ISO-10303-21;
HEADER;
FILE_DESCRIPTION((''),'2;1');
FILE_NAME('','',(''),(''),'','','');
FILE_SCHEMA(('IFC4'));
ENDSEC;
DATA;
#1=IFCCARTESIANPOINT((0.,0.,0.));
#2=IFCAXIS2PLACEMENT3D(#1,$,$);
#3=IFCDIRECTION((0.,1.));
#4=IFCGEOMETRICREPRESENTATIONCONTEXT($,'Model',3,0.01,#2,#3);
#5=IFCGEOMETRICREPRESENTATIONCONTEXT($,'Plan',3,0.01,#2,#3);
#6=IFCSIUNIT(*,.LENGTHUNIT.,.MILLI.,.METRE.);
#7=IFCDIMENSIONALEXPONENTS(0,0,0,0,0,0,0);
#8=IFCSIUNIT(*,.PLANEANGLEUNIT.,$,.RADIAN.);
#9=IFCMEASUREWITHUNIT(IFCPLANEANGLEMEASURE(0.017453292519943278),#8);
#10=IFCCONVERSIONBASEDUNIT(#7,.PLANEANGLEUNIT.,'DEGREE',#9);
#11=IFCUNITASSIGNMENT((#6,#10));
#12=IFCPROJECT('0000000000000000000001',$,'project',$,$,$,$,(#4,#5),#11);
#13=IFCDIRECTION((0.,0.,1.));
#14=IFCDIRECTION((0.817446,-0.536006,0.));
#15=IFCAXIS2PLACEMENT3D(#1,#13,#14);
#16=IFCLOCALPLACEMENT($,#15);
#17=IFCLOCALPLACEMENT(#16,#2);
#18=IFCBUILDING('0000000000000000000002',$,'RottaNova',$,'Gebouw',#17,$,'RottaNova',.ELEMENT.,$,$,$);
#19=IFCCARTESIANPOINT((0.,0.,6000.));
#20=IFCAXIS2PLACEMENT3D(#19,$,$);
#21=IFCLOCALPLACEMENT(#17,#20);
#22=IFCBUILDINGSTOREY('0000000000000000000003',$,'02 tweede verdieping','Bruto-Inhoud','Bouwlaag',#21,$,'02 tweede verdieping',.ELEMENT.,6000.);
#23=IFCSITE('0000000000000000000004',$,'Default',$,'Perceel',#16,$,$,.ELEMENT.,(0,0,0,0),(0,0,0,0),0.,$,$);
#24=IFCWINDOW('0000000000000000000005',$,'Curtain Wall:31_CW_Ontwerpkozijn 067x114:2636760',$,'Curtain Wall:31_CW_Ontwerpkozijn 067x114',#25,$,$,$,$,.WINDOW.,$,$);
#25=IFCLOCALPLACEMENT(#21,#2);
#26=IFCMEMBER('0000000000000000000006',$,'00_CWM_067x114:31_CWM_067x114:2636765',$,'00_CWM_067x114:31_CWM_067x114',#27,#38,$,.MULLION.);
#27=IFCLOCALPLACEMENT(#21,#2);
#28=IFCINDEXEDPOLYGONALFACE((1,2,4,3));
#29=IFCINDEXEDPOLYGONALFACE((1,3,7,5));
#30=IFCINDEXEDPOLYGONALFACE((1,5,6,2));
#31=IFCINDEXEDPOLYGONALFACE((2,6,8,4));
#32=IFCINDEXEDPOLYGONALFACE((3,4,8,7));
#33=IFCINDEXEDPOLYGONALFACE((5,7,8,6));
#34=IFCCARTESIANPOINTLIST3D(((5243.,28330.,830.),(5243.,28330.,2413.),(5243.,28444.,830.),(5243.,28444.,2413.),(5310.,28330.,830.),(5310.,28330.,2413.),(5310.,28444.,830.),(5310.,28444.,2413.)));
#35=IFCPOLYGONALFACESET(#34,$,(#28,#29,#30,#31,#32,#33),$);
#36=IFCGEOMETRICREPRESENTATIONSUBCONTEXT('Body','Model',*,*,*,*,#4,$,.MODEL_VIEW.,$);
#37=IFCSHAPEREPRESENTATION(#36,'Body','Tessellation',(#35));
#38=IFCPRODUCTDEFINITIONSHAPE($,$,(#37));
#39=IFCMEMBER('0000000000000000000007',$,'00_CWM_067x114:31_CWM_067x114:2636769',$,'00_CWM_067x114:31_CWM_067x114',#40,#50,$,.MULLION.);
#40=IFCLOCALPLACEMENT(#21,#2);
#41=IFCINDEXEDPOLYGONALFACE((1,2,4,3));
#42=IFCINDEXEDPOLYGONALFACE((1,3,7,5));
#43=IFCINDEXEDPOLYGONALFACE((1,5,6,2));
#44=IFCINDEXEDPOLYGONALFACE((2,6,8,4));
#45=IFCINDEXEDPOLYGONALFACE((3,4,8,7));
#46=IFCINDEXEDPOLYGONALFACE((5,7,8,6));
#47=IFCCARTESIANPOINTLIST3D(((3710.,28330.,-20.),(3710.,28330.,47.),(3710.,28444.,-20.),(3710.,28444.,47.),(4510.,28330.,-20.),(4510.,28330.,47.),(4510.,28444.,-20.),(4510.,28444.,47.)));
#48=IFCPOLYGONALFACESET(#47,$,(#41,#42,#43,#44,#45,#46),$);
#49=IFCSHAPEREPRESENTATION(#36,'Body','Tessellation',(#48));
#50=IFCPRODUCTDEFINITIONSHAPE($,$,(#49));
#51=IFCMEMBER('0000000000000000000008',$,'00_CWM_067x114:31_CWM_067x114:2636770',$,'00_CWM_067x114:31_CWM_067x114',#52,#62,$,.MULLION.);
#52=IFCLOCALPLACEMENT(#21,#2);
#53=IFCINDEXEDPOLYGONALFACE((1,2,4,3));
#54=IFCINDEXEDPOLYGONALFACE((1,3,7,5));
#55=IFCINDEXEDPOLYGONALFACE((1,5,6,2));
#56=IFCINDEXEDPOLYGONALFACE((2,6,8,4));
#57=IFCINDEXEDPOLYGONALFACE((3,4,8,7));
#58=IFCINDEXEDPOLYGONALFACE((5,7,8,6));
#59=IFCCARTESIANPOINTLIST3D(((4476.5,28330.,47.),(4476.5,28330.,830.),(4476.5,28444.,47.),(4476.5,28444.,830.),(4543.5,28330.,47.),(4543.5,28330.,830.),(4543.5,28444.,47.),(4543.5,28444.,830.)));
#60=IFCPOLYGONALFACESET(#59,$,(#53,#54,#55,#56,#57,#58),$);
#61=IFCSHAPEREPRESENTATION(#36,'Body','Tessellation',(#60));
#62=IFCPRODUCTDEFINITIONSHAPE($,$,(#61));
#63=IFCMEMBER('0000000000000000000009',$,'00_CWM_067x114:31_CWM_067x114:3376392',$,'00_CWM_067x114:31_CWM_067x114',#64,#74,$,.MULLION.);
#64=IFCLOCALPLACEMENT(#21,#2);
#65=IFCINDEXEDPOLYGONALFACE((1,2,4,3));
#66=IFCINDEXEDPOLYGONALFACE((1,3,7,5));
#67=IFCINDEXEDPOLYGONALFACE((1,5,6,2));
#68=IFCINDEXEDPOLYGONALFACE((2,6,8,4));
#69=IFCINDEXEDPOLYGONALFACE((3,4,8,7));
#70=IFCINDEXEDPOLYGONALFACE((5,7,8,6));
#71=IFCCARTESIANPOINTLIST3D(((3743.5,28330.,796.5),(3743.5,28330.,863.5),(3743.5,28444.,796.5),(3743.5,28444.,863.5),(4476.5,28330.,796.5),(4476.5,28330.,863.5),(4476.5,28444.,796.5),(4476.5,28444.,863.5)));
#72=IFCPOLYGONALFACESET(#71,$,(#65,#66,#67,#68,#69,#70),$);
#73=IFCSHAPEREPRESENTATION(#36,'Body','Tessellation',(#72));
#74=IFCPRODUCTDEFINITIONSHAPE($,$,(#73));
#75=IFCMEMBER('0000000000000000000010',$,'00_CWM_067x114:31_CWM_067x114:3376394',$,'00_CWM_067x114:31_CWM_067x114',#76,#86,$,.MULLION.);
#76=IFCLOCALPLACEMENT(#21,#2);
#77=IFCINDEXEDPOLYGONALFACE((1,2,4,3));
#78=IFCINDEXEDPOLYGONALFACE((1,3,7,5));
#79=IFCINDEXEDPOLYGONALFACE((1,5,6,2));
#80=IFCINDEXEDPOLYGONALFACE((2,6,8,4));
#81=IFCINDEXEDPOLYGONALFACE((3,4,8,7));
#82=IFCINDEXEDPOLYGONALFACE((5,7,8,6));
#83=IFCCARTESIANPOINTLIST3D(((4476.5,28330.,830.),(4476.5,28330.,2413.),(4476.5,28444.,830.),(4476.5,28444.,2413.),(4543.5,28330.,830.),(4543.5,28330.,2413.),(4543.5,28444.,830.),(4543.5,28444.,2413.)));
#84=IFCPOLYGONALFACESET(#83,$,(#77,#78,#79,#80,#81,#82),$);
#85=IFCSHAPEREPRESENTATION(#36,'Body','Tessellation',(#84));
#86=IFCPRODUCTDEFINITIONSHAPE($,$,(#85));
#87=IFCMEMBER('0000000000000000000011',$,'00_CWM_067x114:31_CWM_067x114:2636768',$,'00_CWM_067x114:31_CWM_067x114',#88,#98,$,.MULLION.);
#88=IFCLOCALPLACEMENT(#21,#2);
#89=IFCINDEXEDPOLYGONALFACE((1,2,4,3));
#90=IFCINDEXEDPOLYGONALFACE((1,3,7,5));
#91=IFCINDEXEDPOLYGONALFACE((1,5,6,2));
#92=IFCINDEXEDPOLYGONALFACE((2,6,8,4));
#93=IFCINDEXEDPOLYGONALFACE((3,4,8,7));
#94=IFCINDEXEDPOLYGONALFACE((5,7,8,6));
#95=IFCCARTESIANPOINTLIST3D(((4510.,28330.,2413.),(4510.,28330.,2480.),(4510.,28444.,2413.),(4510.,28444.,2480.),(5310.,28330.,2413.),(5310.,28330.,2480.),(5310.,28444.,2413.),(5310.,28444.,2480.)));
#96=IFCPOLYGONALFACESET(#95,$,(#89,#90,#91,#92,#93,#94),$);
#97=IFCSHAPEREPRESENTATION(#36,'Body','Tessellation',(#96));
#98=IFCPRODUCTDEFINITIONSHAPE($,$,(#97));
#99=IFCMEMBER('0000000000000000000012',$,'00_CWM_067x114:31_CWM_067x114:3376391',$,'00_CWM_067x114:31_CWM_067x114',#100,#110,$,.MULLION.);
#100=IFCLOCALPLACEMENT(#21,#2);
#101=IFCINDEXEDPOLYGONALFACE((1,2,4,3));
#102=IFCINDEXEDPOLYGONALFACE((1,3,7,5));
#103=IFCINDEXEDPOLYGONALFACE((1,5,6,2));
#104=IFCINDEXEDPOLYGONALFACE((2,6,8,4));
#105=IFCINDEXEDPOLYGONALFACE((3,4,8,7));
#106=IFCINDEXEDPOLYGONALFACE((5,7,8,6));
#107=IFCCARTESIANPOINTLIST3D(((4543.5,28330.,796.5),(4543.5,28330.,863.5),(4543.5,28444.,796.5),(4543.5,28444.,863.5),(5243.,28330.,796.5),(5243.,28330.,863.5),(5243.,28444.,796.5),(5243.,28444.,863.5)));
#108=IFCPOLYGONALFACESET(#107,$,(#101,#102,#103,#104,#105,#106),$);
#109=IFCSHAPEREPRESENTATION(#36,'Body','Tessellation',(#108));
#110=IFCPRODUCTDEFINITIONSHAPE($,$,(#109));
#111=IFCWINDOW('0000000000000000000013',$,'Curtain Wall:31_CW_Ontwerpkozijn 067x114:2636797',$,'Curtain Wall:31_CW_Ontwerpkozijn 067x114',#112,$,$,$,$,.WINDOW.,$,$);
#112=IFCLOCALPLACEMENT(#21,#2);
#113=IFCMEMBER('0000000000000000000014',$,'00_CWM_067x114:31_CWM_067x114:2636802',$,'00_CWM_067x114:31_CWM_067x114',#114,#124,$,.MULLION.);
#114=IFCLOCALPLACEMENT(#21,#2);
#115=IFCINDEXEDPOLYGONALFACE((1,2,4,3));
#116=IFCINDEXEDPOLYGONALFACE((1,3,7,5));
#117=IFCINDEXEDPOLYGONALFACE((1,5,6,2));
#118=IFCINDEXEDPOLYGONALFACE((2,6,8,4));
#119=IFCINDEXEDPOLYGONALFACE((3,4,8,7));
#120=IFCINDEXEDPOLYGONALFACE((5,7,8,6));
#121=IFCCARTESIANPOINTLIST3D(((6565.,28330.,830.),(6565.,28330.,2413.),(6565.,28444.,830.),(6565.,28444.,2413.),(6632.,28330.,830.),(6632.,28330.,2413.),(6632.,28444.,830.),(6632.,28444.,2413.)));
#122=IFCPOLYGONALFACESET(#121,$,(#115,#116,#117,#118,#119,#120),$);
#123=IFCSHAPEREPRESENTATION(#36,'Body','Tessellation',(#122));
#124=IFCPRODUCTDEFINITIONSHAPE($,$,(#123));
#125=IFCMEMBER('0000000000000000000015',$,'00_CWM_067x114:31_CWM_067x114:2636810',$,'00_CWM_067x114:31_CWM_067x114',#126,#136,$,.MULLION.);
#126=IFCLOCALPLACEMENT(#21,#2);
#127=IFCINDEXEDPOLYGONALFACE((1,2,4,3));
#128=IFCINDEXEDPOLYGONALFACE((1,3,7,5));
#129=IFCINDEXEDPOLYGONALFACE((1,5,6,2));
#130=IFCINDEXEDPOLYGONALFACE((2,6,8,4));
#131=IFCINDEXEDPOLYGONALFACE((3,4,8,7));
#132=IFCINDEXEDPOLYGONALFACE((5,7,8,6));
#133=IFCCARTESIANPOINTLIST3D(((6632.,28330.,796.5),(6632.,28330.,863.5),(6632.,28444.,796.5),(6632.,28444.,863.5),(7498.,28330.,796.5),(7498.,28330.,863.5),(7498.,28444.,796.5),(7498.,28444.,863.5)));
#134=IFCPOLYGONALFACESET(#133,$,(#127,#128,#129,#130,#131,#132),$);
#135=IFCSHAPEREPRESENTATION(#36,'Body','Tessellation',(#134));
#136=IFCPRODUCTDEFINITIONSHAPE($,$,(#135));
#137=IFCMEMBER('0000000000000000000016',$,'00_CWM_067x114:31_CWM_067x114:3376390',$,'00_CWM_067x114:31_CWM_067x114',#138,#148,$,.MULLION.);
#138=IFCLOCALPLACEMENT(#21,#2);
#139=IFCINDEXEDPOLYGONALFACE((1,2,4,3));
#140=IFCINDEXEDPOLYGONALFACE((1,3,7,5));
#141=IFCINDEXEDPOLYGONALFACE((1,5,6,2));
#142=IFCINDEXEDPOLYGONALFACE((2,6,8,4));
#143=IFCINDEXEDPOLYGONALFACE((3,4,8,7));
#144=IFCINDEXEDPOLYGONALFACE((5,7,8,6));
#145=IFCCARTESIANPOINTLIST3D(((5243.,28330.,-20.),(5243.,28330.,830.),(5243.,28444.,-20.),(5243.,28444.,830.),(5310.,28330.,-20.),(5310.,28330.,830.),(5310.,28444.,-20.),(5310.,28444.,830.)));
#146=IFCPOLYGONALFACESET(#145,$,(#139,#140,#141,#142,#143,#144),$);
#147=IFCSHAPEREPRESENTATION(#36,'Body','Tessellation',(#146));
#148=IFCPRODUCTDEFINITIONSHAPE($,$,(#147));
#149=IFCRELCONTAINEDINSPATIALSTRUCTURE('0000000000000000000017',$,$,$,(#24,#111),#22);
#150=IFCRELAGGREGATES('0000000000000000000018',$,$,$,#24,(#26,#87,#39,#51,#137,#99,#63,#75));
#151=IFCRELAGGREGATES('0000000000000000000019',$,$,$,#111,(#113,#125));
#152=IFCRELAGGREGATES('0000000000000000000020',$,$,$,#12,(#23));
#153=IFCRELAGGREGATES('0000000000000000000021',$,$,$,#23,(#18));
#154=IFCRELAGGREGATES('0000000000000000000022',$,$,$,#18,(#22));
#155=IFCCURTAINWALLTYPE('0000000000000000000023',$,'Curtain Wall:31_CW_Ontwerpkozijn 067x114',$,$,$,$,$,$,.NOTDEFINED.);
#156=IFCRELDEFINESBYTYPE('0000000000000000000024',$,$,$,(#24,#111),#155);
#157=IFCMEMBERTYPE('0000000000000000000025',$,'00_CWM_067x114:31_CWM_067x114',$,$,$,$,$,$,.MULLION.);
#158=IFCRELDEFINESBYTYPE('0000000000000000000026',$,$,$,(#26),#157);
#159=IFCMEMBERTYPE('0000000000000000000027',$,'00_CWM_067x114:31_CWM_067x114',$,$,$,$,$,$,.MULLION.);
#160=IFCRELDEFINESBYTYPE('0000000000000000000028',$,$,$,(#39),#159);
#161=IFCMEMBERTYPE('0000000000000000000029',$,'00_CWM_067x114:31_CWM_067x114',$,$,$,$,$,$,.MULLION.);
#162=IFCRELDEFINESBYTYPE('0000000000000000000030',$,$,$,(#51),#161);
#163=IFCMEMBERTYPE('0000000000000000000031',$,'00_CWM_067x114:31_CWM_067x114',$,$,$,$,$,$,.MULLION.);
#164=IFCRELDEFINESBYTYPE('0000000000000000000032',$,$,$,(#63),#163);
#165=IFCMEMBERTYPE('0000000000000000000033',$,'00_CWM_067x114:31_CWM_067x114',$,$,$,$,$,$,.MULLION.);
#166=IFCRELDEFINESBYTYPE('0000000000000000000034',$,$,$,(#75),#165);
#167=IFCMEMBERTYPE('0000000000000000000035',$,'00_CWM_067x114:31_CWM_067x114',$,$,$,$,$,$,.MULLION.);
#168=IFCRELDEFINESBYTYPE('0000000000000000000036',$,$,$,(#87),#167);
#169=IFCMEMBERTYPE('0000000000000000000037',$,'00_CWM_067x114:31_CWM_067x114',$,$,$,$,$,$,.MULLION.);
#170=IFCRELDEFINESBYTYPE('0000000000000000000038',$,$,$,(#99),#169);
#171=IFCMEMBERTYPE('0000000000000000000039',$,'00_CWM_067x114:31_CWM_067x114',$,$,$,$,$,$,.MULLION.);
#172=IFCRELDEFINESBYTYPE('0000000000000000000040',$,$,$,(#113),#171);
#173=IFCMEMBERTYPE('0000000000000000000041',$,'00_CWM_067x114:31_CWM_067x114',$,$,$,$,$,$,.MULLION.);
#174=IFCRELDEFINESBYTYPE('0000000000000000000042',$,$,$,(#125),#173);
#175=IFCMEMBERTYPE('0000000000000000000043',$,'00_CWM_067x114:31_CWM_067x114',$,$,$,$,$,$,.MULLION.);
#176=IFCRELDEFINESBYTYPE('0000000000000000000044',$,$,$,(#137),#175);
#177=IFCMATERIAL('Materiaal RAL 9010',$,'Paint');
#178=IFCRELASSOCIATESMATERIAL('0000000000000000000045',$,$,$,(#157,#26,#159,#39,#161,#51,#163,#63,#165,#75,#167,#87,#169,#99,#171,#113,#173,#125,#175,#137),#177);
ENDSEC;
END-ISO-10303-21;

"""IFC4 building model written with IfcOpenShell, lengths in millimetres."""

from ifc_helpers import new_model, entity, si_unit, converted_unit, direction, frame, origin, place, context, subcontext, project, spatial, indexed_curve, outline, extrude, source, transform, mapped, material, type_object, type_shapes, element, aggregate, save


model = new_model("IFC4")

# Units and contexts
model_context = context("Model", 3, precision=0.01, world=origin(), true_north=direction((0.0, 1.0)))
plan_context = context("Plan", 3, precision=0.01, world=origin(), true_north=direction((0.0, 1.0)))
body_context = subcontext(model_context, "Body", "Model", "MODEL_VIEW")
ifc_project = project(units=[si_unit("LENGTHUNIT", "METRE", prefix="MILLI"), converted_unit("PLANEANGLEUNIT", "DEGREE", entity("IfcPlaneAngleMeasure", 0.017453292519943278), si_unit("PLANEANGLEUNIT", "RADIAN"), dimensions=[0, 0, 0, 0, 0, 0, 0])], contexts=[model_context, plan_context])

# Site, building, storey
site_placement = place(None, frame((0.0, 0.0, 0.0), z_axis=(0.0, 0.0, 1.0), x_axis=(0.817446, -0.536006, 0.0)))
site = spatial("IfcSite", under=ifc_project, at=site_placement, Name="Default", ObjectType="Perceel", CompositionType="ELEMENT", RefLatitude=(0, 0, 0, 0), RefLongitude=(0, 0, 0, 0), RefElevation=0.0)
building_placement = place(site_placement, origin())
building = spatial("IfcBuilding", under=site, at=building_placement, Name="RottaNova", ObjectType="Gebouw", LongName="RottaNova", CompositionType="ELEMENT")
storey_placement = place(building_placement, frame((0.0, 0.0, 6000.0)))
storey = spatial("IfcBuildingStorey", under=building, at=storey_placement, Name="02 tweede verdieping", Description="Bruto-Inhoud", ObjectType="Bouwlaag", LongName="02 tweede verdieping", CompositionType="ELEMENT", Elevation=6000.0)

# Windows, members
curtain_wall_type = type_object("IfcCurtainWallType", Name="Curtain Wall:31_CW_Ontwerpkozijn 067x114", PredefinedType="NOTDEFINED")
window_1_placement = place(storey_placement, frame((0.0, 0.0, -6000.0)))
window_1 = element("IfcWindow", 1, at=window_1_placement, inside=storey, type_object=curtain_wall_type, Name="Curtain Wall:31_CW_Ontwerpkozijn 067x114:2636760", ObjectType="Curtain Wall:31_CW_Ontwerpkozijn 067x114", PredefinedType="WINDOW")
ifc_material_1 = material(Name="Materiaal RAL 9010", Category="Paint")
member_type_1 = type_object("IfcMemberType", Name="00_CWM_067x114:31_CWM_067x114", PredefinedType="MULLION", material=ifc_material_1)
shared_shape_1 = source(origin(), body_context, "Body", "SweptSolid", [
    extrude(outline(indexed_curve([(-33.5, -57.0), (33.5, -57.0), (33.5, 57.0), (-33.5, 57.0), (-33.5, -57.0)], self_intersect=False)), frame((-33.5, 57.0, -1583.0), z_axis=(0.0, 0.0, 1.0), x_axis=(-1.0, 0.0, 0.0)), (0.0, 0.0, 1.0), 1583.0),
])
type_shapes(member_type_1, [shared_shape_1])
member_1_placement = place(window_1_placement, frame((5310.0, 28330.0, 8413.0)))
member_1 = element("IfcMember", 2, at=member_1_placement, type_object=member_type_1, material=ifc_material_1, Name="00_CWM_067x114:31_CWM_067x114:2636765", ObjectType="00_CWM_067x114:31_CWM_067x114", PredefinedType="MULLION", context=body_context, shape_type="MappedRepresentation", body=[
    mapped(shared_shape_1, transform((0.0, 0.0, 0.0), scale=1.0)),
])
member_type_2 = type_object("IfcMemberType", Name="00_CWM_067x114:31_CWM_067x114", PredefinedType="MULLION", material=ifc_material_1)
shared_shape_2 = source(origin(), body_context, "Body", "SweptSolid", [
    extrude(outline(indexed_curve([(-33.5, -57.0), (33.5, -57.0), (33.5, 57.0), (-33.5, 57.0), (-33.5, -57.0)], self_intersect=False)), frame((-33.5, 57.0, -800.0), z_axis=(0.0, 0.0, 1.0), x_axis=(-1.0, 0.0, 0.0)), (0.0, 0.0, 1.0), 800.0),
])
type_shapes(member_type_2, [shared_shape_2])
member_2_placement = place(window_1_placement, frame((4510.0, 28330.0, 5980.0), z_axis=(1.0, 0.0, 0.0), x_axis=(0.0, 0.0, -1.0)))
member_2 = element("IfcMember", 3, at=member_2_placement, type_object=member_type_2, material=ifc_material_1, Name="00_CWM_067x114:31_CWM_067x114:2636769", ObjectType="00_CWM_067x114:31_CWM_067x114", PredefinedType="MULLION", context=body_context, shape_type="MappedRepresentation", body=[
    mapped(shared_shape_2, transform((0.0, 0.0, 0.0), scale=1.0)),
])
member_type_3 = type_object("IfcMemberType", Name="00_CWM_067x114:31_CWM_067x114", PredefinedType="MULLION", material=ifc_material_1)
shared_shape_3 = source(origin(), body_context, "Body", "SweptSolid", [
    extrude(outline(indexed_curve([(-33.5, -57.0), (33.5, -57.0), (33.5, 57.0), (-33.5, 57.0), (-33.5, -57.0)], self_intersect=False)), frame((0.0, 57.0, -783.0), z_axis=(0.0, 0.0, 1.0), x_axis=(-1.0, 0.0, 0.0)), (0.0, 0.0, 1.0), 783.0),
])
type_shapes(member_type_3, [shared_shape_3])
member_3_placement = place(window_1_placement, frame((4510.0, 28330.0, 6047.0), z_axis=(0.0, 0.0, -1.0), x_axis=(-1.0, 0.0, 0.0)))
member_3 = element("IfcMember", 4, at=member_3_placement, type_object=member_type_3, material=ifc_material_1, Name="00_CWM_067x114:31_CWM_067x114:2636770", ObjectType="00_CWM_067x114:31_CWM_067x114", PredefinedType="MULLION", context=body_context, shape_type="MappedRepresentation", body=[
    mapped(shared_shape_3, transform((0.0, 0.0, 0.0), scale=1.0)),
])
member_type_4 = type_object("IfcMemberType", Name="00_CWM_067x114:31_CWM_067x114", PredefinedType="MULLION", material=ifc_material_1)
shared_shape_4 = source(origin(), body_context, "Body", "SweptSolid", [
    extrude(outline(indexed_curve([(-33.5, -57.0), (33.5, -57.0), (33.5, 57.0), (-33.5, 57.0), (-33.5, -57.0)], self_intersect=False)), frame((0.0, 57.0, -733.0), z_axis=(0.0, 0.0, 1.0), x_axis=(-1.0, 0.0, 0.0)), (0.0, 0.0, 1.0), 733.0),
])
type_shapes(member_type_4, [shared_shape_4])
member_4_placement = place(window_1_placement, frame((3743.5, 28330.0, 6830.0), z_axis=(-1.0, 0.0, 0.0), x_axis=(0.0, 0.0, 1.0)))
member_4 = element("IfcMember", 5, at=member_4_placement, type_object=member_type_4, material=ifc_material_1, Name="00_CWM_067x114:31_CWM_067x114:3376392", ObjectType="00_CWM_067x114:31_CWM_067x114", PredefinedType="MULLION", context=body_context, shape_type="MappedRepresentation", body=[
    mapped(shared_shape_4, transform((0.0, 0.0, 0.0), scale=1.0)),
])
member_type_5 = type_object("IfcMemberType", Name="00_CWM_067x114:31_CWM_067x114", PredefinedType="MULLION", material=ifc_material_1)
shared_shape_5 = source(origin(), body_context, "Body", "SweptSolid", [
    extrude(outline(indexed_curve([(-33.5, -57.0), (33.5, -57.0), (33.5, 57.0), (-33.5, 57.0), (-33.5, -57.0)], self_intersect=False)), frame((0.0, 57.0, -1583.0), z_axis=(0.0, 0.0, 1.0), x_axis=(-1.0, 0.0, 0.0)), (0.0, 0.0, 1.0), 1583.0),
])
type_shapes(member_type_5, [shared_shape_5])
member_5_placement = place(window_1_placement, frame((4510.0, 28330.0, 6830.0), z_axis=(0.0, 0.0, -1.0), x_axis=(-1.0, 0.0, 0.0)))
member_5 = element("IfcMember", 6, at=member_5_placement, type_object=member_type_5, material=ifc_material_1, Name="00_CWM_067x114:31_CWM_067x114:3376394", ObjectType="00_CWM_067x114:31_CWM_067x114", PredefinedType="MULLION", context=body_context, shape_type="MappedRepresentation", body=[
    mapped(shared_shape_5, transform((0.0, 0.0, 0.0), scale=1.0)),
])
member_type_6 = type_object("IfcMemberType", Name="00_CWM_067x114:31_CWM_067x114", PredefinedType="MULLION", material=ifc_material_1)
shared_shape_6 = source(origin(), body_context, "Body", "SweptSolid", [
    extrude(outline(indexed_curve([(-33.5, -57.0), (33.5, -57.0), (33.5, 57.0), (-33.5, 57.0), (-33.5, -57.0)], self_intersect=False)), frame((-33.5, 57.0, -800.0), z_axis=(0.0, 0.0, 1.0), x_axis=(-1.0, 0.0, 0.0)), (0.0, 0.0, 1.0), 800.0),
])
type_shapes(member_type_6, [shared_shape_6])
member_6_placement = place(window_1_placement, frame((4510.0, 28330.0, 8480.0), z_axis=(-1.0, 0.0, 0.0), x_axis=(0.0, 0.0, 1.0)))
member_6 = element("IfcMember", 7, at=member_6_placement, type_object=member_type_6, material=ifc_material_1, Name="00_CWM_067x114:31_CWM_067x114:2636768", ObjectType="00_CWM_067x114:31_CWM_067x114", PredefinedType="MULLION", context=body_context, shape_type="MappedRepresentation", body=[
    mapped(shared_shape_6, transform((0.0, 0.0, 0.0), scale=1.0)),
])
member_type_7 = type_object("IfcMemberType", Name="00_CWM_067x114:31_CWM_067x114", PredefinedType="MULLION", material=ifc_material_1)
shared_shape_7 = source(origin(), body_context, "Body", "SweptSolid", [
    extrude(outline(indexed_curve([(-33.5, -57.0), (33.5, -57.0), (33.5, 57.0), (-33.5, 57.0), (-33.5, -57.0)], self_intersect=False)), frame((0.0, 57.0, -699.5), z_axis=(0.0, 0.0, 1.0), x_axis=(-1.0, 0.0, 0.0)), (0.0, 0.0, 1.0), 699.5),
])
type_shapes(member_type_7, [shared_shape_7])
member_7_placement = place(window_1_placement, frame((4543.5, 28330.0, 6830.0), z_axis=(-1.0, 0.0, 0.0), x_axis=(0.0, 0.0, 1.0)))
member_7 = element("IfcMember", 8, at=member_7_placement, type_object=member_type_7, material=ifc_material_1, Name="00_CWM_067x114:31_CWM_067x114:3376391", ObjectType="00_CWM_067x114:31_CWM_067x114", PredefinedType="MULLION", context=body_context, shape_type="MappedRepresentation", body=[
    mapped(shared_shape_7, transform((0.0, 0.0, 0.0), scale=1.0)),
])
window_2_placement = place(storey_placement, frame((0.0, 0.0, -6000.0)))
window_2 = element("IfcWindow", 9, at=window_2_placement, inside=storey, type_object=curtain_wall_type, Name="Curtain Wall:31_CW_Ontwerpkozijn 067x114:2636797", ObjectType="Curtain Wall:31_CW_Ontwerpkozijn 067x114", PredefinedType="WINDOW")
member_type_8 = type_object("IfcMemberType", Name="00_CWM_067x114:31_CWM_067x114", PredefinedType="MULLION", material=ifc_material_1)
shared_shape_8 = source(origin(), body_context, "Body", "SweptSolid", [
    extrude(outline(indexed_curve([(-33.5, -57.0), (33.5, -57.0), (33.5, 57.0), (-33.5, 57.0), (-33.5, -57.0)], self_intersect=False)), frame((-33.5, -57.0, -1583.0), z_axis=(0.0, 0.0, 1.0), x_axis=(-1.0, 0.0, 0.0)), (0.0, 0.0, 1.0), 1583.0),
])
type_shapes(member_type_8, [shared_shape_8])
member_8_placement = place(window_2_placement, frame((6565.0, 28330.0, 8413.0), z_axis=(0.0, 0.0, 1.0), x_axis=(-1.0, 0.0, 0.0)))
member_8 = element("IfcMember", 10, at=member_8_placement, type_object=member_type_8, material=ifc_material_1, Name="00_CWM_067x114:31_CWM_067x114:2636802", ObjectType="00_CWM_067x114:31_CWM_067x114", PredefinedType="MULLION", context=body_context, shape_type="MappedRepresentation", body=[
    mapped(shared_shape_8, transform((0.0, 0.0, 0.0), scale=1.0)),
])
member_type_9 = type_object("IfcMemberType", Name="00_CWM_067x114:31_CWM_067x114", PredefinedType="MULLION", material=ifc_material_1)
shared_shape_9 = source(origin(), body_context, "Body", "SweptSolid", [
    extrude(outline(indexed_curve([(-33.5, -57.0), (33.5, -57.0), (33.5, 57.0), (-33.5, 57.0), (-33.5, -57.0)], self_intersect=False)), frame((0.0, -57.0, -866.0), z_axis=(0.0, 0.0, 1.0), x_axis=(-1.0, 0.0, 0.0)), (0.0, 0.0, 1.0), 866.0),
])
type_shapes(member_type_9, [shared_shape_9])
member_9_placement = place(window_2_placement, frame((7498.0, 28330.0, 6830.0), z_axis=(1.0, 0.0, 0.0), x_axis=(0.0, 0.0, 1.0)))
member_9 = element("IfcMember", 11, at=member_9_placement, type_object=member_type_9, material=ifc_material_1, Name="00_CWM_067x114:31_CWM_067x114:2636810", ObjectType="00_CWM_067x114:31_CWM_067x114", PredefinedType="MULLION", context=body_context, shape_type="MappedRepresentation", body=[
    mapped(shared_shape_9, transform((0.0, 0.0, 0.0), scale=1.0)),
])

# Member
member_type_10 = type_object("IfcMemberType", Name="00_CWM_067x114:31_CWM_067x114", PredefinedType="MULLION", material=ifc_material_1)
shared_shape_10 = source(origin(), body_context, "Body", "SweptSolid", [
    extrude(outline(indexed_curve([(-33.5, -57.0), (33.5, -57.0), (33.5, 57.0), (-33.5, 57.0), (-33.5, -57.0)], self_intersect=False)), frame((-33.5, 57.0, -850.0), z_axis=(0.0, 0.0, 1.0), x_axis=(-1.0, 0.0, 0.0)), (0.0, 0.0, 1.0), 850.0),
])
type_shapes(member_type_10, [shared_shape_10])
member_10_placement = place(window_1_placement, frame((5310.0, 28330.0, 6830.0)))
member_10 = element("IfcMember", 12, at=member_10_placement, type_object=member_type_10, material=ifc_material_1, Name="00_CWM_067x114:31_CWM_067x114:3376390", ObjectType="00_CWM_067x114:31_CWM_067x114", PredefinedType="MULLION", context=body_context, shape_type="MappedRepresentation", body=[
    mapped(shared_shape_10, transform((0.0, 0.0, 0.0), scale=1.0)),
])

aggregate(window_1, [member_1, member_6, member_2, member_3, member_10, member_7, member_4, member_5])
aggregate(window_2, [member_8, member_9])

save(model, "model.ifc")
